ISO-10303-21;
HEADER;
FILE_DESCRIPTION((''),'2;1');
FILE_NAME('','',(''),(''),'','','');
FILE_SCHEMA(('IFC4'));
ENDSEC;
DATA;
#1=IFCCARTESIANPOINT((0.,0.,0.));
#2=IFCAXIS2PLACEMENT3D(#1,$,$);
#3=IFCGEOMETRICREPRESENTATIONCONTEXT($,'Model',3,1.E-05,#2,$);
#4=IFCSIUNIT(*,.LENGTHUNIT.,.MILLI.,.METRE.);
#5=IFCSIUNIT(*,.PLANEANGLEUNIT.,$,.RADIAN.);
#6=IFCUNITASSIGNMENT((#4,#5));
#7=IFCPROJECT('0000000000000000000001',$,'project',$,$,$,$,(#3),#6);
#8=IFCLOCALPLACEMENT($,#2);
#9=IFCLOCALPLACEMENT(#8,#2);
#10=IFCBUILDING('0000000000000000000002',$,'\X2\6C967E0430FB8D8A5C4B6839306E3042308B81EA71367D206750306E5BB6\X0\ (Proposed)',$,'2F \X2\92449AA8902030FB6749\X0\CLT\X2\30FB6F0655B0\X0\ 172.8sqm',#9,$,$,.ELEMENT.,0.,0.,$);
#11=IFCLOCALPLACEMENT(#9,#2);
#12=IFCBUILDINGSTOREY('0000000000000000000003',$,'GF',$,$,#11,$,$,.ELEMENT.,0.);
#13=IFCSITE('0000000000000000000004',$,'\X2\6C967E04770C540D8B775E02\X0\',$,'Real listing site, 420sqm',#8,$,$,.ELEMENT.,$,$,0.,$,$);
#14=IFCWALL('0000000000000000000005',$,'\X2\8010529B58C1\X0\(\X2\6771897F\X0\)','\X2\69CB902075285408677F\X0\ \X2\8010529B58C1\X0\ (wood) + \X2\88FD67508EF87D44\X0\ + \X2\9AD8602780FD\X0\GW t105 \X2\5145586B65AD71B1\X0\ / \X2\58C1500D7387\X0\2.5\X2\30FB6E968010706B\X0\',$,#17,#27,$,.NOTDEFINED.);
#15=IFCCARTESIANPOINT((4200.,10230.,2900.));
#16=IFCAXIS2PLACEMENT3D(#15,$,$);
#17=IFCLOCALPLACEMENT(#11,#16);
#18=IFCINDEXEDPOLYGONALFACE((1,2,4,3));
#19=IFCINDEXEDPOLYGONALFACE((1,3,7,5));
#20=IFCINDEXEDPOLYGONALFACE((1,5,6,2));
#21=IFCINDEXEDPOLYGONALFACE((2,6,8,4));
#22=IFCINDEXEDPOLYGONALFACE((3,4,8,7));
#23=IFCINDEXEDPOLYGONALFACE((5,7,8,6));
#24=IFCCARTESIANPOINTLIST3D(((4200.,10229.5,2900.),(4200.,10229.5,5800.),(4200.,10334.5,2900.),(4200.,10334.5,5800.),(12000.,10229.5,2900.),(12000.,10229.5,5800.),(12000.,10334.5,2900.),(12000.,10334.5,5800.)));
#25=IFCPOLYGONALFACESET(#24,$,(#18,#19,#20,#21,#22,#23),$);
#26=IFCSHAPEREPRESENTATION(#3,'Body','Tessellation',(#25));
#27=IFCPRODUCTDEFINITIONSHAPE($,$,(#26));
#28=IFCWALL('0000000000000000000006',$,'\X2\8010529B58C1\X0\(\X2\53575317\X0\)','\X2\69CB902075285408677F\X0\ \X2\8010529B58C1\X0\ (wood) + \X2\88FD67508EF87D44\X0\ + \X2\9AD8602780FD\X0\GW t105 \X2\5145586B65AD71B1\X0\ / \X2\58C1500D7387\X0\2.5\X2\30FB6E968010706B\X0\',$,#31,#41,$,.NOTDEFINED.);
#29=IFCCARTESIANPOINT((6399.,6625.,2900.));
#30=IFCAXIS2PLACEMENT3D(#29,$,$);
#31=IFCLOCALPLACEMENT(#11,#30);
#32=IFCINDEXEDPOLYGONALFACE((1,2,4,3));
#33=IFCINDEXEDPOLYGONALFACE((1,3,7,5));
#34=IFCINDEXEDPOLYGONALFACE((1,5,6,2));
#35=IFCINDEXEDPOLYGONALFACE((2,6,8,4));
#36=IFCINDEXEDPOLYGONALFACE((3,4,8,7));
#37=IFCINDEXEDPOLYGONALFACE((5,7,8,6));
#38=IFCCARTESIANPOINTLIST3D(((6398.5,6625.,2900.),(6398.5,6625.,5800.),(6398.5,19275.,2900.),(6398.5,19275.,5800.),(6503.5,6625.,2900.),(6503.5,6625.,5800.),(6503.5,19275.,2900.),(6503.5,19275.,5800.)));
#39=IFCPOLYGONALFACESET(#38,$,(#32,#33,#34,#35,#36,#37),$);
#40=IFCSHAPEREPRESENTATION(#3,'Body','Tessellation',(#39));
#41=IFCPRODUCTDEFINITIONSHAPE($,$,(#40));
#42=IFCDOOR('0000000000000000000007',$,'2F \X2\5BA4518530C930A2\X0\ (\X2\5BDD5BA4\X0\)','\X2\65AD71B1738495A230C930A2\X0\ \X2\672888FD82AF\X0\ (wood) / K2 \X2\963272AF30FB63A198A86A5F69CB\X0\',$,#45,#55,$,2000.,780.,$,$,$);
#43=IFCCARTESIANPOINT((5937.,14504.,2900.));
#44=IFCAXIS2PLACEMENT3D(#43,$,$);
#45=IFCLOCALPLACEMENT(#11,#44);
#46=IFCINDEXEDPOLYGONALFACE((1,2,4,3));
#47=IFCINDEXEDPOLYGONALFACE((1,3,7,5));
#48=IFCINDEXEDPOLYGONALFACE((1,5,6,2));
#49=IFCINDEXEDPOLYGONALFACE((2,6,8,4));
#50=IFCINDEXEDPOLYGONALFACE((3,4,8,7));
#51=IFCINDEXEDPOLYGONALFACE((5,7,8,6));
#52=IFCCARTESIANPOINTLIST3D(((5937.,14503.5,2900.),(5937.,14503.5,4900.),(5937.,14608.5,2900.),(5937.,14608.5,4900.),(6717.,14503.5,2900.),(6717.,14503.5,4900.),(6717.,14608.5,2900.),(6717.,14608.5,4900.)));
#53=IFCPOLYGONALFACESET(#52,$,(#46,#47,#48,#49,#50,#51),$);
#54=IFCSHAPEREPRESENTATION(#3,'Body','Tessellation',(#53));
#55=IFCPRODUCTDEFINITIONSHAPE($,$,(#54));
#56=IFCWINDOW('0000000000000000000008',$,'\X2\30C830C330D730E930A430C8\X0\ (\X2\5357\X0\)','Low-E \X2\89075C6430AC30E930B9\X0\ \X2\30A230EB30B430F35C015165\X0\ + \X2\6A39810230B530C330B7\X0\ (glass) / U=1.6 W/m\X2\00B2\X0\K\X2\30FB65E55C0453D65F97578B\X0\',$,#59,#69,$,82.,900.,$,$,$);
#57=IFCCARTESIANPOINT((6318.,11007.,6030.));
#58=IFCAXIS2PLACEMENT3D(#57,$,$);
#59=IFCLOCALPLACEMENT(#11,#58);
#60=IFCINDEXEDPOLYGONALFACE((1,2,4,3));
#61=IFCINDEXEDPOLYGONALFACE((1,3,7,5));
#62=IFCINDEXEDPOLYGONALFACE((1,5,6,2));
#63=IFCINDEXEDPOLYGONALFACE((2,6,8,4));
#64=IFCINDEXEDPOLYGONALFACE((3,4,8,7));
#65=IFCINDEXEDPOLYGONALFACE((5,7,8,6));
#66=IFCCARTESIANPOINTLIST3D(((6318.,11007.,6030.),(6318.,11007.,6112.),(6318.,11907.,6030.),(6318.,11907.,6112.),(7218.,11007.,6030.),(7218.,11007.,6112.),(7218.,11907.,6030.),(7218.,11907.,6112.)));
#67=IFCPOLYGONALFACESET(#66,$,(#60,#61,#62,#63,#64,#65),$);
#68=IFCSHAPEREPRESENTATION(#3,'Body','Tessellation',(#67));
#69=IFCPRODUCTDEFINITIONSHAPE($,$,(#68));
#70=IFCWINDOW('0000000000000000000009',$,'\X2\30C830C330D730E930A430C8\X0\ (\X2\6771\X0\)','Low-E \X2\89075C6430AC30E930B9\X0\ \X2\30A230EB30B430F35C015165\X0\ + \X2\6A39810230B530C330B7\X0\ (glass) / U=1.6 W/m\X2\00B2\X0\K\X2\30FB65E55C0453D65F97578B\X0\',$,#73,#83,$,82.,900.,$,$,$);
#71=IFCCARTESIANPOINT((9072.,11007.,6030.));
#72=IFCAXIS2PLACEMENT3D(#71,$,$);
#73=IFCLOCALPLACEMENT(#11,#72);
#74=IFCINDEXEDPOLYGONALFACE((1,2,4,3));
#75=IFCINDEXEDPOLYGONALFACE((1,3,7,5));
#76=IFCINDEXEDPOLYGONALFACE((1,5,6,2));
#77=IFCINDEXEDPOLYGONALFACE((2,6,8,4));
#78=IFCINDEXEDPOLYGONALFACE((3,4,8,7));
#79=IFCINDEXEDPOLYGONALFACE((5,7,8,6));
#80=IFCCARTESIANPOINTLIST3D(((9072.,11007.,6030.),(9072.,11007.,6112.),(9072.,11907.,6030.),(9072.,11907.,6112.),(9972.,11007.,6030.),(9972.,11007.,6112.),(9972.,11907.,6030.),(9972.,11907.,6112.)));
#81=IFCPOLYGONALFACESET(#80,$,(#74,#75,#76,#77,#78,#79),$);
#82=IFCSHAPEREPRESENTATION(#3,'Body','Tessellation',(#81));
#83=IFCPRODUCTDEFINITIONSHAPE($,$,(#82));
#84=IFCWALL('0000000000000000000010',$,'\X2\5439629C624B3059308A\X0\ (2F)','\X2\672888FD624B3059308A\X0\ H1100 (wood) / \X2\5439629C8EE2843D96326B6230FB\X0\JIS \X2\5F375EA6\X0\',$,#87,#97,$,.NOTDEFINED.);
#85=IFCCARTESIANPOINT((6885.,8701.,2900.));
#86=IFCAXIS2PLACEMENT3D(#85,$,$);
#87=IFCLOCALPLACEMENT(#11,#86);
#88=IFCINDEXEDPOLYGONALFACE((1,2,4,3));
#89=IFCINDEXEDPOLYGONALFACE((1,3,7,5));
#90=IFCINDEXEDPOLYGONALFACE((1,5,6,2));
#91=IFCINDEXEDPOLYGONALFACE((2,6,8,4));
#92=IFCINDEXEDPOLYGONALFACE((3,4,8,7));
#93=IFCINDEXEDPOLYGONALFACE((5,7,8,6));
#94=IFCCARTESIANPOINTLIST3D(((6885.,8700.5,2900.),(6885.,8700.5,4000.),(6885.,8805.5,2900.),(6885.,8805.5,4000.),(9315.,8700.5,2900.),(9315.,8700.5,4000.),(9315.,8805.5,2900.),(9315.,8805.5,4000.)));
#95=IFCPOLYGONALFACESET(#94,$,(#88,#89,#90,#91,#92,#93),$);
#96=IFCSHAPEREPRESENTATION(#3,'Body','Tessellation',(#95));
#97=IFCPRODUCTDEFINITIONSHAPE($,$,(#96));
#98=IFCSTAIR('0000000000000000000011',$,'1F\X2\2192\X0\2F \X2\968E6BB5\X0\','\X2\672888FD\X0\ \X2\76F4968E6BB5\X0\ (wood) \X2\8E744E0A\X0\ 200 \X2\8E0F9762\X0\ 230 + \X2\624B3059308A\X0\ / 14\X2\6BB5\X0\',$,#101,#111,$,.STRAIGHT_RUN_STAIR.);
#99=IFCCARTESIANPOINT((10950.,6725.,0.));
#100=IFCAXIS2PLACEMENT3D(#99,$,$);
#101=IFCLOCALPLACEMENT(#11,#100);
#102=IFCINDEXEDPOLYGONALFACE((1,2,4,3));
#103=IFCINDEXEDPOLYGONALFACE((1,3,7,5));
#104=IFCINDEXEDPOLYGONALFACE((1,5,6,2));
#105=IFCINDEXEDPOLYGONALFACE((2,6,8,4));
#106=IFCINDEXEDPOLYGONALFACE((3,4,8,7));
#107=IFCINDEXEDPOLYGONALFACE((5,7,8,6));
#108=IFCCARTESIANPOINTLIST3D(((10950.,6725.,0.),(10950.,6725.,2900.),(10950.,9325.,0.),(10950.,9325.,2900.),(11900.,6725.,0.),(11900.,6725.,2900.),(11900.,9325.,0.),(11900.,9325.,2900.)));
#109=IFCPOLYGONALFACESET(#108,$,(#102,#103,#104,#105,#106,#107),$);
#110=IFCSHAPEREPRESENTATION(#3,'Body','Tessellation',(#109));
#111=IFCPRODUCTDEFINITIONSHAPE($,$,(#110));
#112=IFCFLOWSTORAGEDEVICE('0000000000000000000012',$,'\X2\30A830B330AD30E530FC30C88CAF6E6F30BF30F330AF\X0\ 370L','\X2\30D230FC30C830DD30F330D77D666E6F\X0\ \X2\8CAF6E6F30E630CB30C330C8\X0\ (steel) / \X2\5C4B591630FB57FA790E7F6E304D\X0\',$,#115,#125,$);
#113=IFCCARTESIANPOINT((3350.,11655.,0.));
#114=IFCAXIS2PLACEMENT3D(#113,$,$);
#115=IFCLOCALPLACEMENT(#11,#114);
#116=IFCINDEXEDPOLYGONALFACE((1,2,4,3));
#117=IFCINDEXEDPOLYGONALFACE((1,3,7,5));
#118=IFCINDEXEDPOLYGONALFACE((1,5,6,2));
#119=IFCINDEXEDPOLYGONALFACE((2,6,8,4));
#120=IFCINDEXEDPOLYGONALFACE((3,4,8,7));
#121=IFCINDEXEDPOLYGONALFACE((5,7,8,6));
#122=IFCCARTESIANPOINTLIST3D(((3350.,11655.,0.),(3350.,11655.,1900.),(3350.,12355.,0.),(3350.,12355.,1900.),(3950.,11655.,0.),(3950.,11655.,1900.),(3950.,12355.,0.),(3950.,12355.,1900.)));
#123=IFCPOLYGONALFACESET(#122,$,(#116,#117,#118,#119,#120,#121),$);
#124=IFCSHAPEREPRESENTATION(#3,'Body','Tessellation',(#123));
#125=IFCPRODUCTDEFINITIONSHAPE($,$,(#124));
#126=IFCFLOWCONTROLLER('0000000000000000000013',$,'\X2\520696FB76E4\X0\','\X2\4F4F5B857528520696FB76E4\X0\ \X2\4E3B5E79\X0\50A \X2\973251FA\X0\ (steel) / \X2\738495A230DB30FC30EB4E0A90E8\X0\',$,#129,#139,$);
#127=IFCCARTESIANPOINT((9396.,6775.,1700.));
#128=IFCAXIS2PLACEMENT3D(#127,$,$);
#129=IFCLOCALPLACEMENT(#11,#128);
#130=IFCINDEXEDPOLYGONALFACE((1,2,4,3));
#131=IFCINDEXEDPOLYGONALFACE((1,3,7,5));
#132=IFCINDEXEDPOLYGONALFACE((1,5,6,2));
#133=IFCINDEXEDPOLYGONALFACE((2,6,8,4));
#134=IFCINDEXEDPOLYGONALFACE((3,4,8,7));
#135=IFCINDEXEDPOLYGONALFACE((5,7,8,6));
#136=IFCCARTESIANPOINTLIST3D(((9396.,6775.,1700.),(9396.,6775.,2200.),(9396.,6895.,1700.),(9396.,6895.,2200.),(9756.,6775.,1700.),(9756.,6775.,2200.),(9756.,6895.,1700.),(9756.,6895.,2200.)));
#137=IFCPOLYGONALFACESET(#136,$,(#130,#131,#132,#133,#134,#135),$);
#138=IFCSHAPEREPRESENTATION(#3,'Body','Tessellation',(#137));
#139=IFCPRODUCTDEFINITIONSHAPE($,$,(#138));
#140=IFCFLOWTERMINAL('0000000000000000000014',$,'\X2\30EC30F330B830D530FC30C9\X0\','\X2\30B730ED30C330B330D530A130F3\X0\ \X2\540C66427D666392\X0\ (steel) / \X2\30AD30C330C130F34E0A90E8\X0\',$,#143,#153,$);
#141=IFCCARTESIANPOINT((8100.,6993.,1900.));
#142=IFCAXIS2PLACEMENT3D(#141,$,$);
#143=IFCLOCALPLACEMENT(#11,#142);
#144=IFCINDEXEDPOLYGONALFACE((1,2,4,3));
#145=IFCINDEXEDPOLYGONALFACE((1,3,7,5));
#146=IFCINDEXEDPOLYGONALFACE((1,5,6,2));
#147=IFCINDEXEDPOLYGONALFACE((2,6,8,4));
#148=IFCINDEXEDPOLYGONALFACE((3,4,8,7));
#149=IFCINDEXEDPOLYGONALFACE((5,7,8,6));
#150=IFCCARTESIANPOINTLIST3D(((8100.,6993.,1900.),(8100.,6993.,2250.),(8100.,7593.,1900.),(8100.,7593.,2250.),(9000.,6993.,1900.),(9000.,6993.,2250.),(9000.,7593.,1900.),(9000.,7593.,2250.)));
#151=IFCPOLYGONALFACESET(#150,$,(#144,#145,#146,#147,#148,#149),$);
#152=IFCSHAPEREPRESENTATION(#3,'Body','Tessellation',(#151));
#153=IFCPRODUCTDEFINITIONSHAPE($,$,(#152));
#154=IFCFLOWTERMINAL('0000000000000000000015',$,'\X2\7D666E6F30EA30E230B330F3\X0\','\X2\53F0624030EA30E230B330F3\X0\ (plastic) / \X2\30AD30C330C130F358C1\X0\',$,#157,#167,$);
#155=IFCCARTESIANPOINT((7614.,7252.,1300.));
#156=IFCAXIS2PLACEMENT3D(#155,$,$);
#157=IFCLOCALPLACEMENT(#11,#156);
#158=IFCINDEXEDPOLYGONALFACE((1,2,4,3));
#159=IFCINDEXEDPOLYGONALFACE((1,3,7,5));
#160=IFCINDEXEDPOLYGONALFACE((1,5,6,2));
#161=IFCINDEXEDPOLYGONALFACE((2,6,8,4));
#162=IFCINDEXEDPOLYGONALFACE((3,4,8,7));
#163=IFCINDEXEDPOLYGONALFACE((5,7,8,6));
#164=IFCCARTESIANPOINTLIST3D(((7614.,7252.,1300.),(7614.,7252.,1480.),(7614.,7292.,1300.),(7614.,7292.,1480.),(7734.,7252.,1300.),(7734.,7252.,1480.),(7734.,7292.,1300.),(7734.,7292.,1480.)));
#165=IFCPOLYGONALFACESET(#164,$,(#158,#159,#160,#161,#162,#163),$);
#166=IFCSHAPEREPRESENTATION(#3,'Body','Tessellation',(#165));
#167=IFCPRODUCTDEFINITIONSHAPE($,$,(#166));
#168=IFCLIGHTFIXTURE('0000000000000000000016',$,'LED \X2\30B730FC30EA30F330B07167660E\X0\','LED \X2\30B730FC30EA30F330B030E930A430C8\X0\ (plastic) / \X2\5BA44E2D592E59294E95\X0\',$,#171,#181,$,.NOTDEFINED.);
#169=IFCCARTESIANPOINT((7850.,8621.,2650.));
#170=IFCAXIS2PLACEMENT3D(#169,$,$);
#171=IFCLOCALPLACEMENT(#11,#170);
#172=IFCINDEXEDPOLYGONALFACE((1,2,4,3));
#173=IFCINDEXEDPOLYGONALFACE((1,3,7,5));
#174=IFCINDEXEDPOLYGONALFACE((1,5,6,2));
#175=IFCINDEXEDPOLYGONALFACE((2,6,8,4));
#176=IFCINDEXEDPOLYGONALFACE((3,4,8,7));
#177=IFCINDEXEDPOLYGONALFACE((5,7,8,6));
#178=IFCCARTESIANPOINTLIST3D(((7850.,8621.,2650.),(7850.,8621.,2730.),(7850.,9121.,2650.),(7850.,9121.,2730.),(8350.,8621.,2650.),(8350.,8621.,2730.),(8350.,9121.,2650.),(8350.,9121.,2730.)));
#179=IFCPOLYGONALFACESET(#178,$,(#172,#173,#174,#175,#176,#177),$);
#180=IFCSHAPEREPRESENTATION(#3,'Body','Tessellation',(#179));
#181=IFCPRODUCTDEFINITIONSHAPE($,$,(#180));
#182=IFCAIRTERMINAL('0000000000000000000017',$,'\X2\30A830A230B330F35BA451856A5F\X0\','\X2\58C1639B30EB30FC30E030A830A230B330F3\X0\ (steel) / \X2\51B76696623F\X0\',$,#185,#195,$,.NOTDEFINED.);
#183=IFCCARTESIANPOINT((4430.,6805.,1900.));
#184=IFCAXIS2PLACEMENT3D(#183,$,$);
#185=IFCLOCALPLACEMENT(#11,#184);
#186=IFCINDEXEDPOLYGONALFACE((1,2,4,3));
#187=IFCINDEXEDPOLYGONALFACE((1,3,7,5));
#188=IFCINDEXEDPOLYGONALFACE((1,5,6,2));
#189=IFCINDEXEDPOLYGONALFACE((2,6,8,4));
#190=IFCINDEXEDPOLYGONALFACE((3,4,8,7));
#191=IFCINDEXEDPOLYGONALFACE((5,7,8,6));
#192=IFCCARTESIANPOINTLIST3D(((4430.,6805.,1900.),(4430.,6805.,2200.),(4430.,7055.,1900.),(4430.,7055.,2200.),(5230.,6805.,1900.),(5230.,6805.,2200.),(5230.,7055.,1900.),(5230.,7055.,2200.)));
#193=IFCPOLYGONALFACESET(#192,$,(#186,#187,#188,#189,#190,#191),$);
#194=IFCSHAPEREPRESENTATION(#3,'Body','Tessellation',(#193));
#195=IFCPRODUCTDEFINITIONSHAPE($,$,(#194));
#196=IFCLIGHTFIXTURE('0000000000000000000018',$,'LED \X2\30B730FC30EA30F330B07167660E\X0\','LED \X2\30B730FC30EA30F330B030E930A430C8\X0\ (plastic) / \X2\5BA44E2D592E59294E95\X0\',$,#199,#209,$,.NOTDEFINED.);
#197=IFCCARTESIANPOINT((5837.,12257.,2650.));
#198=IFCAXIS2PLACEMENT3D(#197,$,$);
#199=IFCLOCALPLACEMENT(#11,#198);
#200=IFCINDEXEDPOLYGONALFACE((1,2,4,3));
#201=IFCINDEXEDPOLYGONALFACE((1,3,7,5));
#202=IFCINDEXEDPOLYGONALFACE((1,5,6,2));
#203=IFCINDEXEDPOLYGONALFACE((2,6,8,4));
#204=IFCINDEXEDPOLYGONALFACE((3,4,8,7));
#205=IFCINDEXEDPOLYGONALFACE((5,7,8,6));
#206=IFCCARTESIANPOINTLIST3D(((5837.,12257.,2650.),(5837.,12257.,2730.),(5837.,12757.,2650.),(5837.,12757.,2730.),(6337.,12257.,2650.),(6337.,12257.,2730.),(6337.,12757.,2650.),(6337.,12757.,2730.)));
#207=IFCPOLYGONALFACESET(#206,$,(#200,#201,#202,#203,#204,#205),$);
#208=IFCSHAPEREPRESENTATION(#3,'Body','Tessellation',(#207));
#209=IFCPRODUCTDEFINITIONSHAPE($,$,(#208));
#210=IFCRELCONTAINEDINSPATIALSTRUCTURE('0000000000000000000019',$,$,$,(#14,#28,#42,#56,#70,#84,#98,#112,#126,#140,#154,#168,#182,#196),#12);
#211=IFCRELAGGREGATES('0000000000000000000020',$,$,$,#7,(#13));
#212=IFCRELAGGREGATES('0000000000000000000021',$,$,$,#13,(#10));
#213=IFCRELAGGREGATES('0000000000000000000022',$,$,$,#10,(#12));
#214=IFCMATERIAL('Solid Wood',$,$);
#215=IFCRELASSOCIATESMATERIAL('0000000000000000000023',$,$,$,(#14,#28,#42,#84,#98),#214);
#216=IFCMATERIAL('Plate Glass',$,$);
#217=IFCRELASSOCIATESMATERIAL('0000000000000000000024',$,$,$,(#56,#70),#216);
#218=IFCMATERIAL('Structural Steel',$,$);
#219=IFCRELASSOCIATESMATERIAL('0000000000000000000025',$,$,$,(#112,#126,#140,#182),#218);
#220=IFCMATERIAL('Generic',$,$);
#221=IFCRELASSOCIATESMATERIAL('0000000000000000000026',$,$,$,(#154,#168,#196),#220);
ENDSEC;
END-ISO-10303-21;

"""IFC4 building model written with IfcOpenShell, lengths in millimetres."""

from ifc_helpers import new_model, si_unit, frame, frame_2d, origin, place, context, project, spatial, rectangle, extrude, material, element, fill, save


model = new_model("IFC4")

# Units and contexts
model_context = context("Model", 3, precision=1e-05, world=origin())
ifc_project = project(units=[si_unit("LENGTHUNIT", "METRE", prefix="MILLI"), si_unit("PLANEANGLEUNIT", "RADIAN")], contexts=[model_context])

# Site, building, storey
site_placement = place(None, origin())
site = spatial("IfcSite", under=ifc_project, at=site_placement, Name="沖縄県名護市", ObjectType="Real listing site, 420sqm", CompositionType="ELEMENT", RefElevation=0.0)
building_placement = place(site_placement, origin())
building = spatial("IfcBuilding", under=site, at=building_placement, Name="沖縄・越屋根のある自然素材の家 (Proposed)", ObjectType="2F 鉄骨造・杉CLT・漆喰 172.8sqm", CompositionType="ELEMENT", ElevationOfRefHeight=0.0, ElevationOfTerrain=0.0)
storey_placement = place(building_placement, origin())
storey = spatial("IfcBuildingStorey", under=building, at=storey_placement, Name="GF", CompositionType="ELEMENT", Elevation=0.0)

# Shared definitions
ifc_material_1 = material(Name="Solid Wood")

# Wall
wall_1_placement = place(storey_placement, frame((4200.0, 10230.0, 2900.0)))
element("IfcWall", 1, at=wall_1_placement, inside=storey, material=ifc_material_1, Name="耐力壁(東西)", Description="構造用合板 耐力壁 (wood) + 製材軸組 + 高性能GW t105 充填断熱 / 壁倍率2.5・準耐火", PredefinedType="NOTDEFINED", context=model_context, shape_type="SweptSolid", body=[
    extrude(rectangle(XDim=7800.0, YDim=105.0, at=frame_2d((3900.0, 52.0))), frame((4200.0, 10230.0, 2900.0)), (0.0, 0.0, 1.0), 2900.0),
])

# Wall, opening, door
wall_2_placement = place(storey_placement, frame((6399.0, 6625.0, 2900.0)))
wall_2 = element("IfcWall", 2, at=wall_2_placement, inside=storey, material=ifc_material_1, Name="耐力壁(南北)", Description="構造用合板 耐力壁 (wood) + 製材軸組 + 高性能GW t105 充填断熱 / 壁倍率2.5・準耐火", PredefinedType="NOTDEFINED", context=model_context, shape_type="SweptSolid", body=[
    extrude(rectangle(XDim=105.0, YDim=12650.0, at=frame_2d((52.0, 6325.0))), frame((6399.0, 6625.0, 2900.0)), (0.0, 0.0, 1.0), 2900.0),
])
opening_placement = place(storey_placement, frame((5937.0, 14504.0, 2900.0)))
opening = element("IfcOpeningElement", 3, at=opening_placement, cuts=wall_2, PredefinedType="NOTDEFINED", context=model_context, shape_type="SweptSolid", body=[
    extrude(rectangle(XDim=780.0, YDim=105.0, at=frame_2d((390.0, 52.0))), frame((5937.0, 14504.0, 2900.0)), (0.0, 0.0, 1.0), 2000.0),
])
door_placement = place(storey_placement, frame((5937.0, 14504.0, 2900.0)))
door = element("IfcDoor", 4, at=door_placement, inside=storey, material=ifc_material_1, Name="2F 室内ドア (寝室)", Description="断熱玄関ドア 木製芯 (wood) / K2 防犯・採風機構", OverallHeight=2000.0, OverallWidth=780.0, context=model_context, shape_type="SweptSolid", body=[
    extrude(rectangle(XDim=780.0, YDim=105.0, at=frame_2d((390.0, 52.0))), frame((5937.0, 14504.0, 2900.0)), (0.0, 0.0, 1.0), 2000.0),
])
fill(opening, door)

# Windows
ifc_material_2 = material(Name="Plate Glass")
window_1_placement = place(storey_placement, frame((6318.0, 11007.0, 6030.0)))
element("IfcWindow", 5, at=window_1_placement, inside=storey, material=ifc_material_2, Name="トップライト (南)", Description="Low-E 複層ガラス アルゴン封入 + 樹脂サッシ (glass) / U=1.6 W/m²K・日射取得型", OverallHeight=82.0, OverallWidth=900.0, context=model_context, shape_type="SweptSolid", body=[
    extrude(rectangle(XDim=900.0, YDim=900.0, at=frame_2d((450.0, 450.0))), frame((6318.0, 11007.0, 6030.0)), (0.0, 0.0, 1.0), 82.0),
])
window_2_placement = place(storey_placement, frame((9072.0, 11007.0, 6030.0)))
element("IfcWindow", 6, at=window_2_placement, inside=storey, material=ifc_material_2, Name="トップライト (東)", Description="Low-E 複層ガラス アルゴン封入 + 樹脂サッシ (glass) / U=1.6 W/m²K・日射取得型", OverallHeight=82.0, OverallWidth=900.0, context=model_context, shape_type="SweptSolid", body=[
    extrude(rectangle(XDim=900.0, YDim=900.0, at=frame_2d((450.0, 450.0))), frame((9072.0, 11007.0, 6030.0)), (0.0, 0.0, 1.0), 82.0),
])

# Wall
wall_3_placement = place(storey_placement, frame((6885.0, 8701.0, 2900.0)))
element("IfcWall", 7, at=wall_3_placement, inside=storey, material=ifc_material_1, Name="吹抜手すり (2F)", Description="木製手すり H1100 (wood) / 吹抜転落防止・JIS 強度", PredefinedType="NOTDEFINED", context=model_context, shape_type="SweptSolid", body=[
    extrude(rectangle(XDim=2430.0, YDim=105.0, at=frame_2d((1215.0, 52.0))), frame((6885.0, 8701.0, 2900.0)), (0.0, 0.0, 1.0), 1100.0),
])

# Stair
stair_placement = place(storey_placement, frame((10950.0, 6725.0, 0.0)))
element("IfcStair", 8, at=stair_placement, inside=storey, material=ifc_material_1, Name="1F→2F 階段", Description="木製 直階段 (wood) 蹴上 200 踏面 230 + 手すり / 14段", PredefinedType="STRAIGHT_RUN_STAIR", context=model_context, shape_type="SweptSolid", body=[
    extrude(rectangle(XDim=950.0, YDim=2600.0, at=frame_2d((475.0, 1300.0))), frame((10950.0, 6725.0, 0.0)), (0.0, 0.0, 1.0), 2900.0),
])

# Flow storage device
ifc_material_3 = material(Name="Structural Steel")
flow_storage_device_placement = place(storey_placement, frame((3350.0, 11655.0, 0.0)))
element("IfcFlowStorageDevice", 9, at=flow_storage_device_placement, inside=storey, material=ifc_material_3, Name="エコキュート貯湯タンク 370L", Description="ヒートポンプ給湯 貯湯ユニット (steel) / 屋外・基礎置き", context=model_context, shape_type="SweptSolid", body=[
    extrude(rectangle(XDim=600.0, YDim=700.0, at=frame_2d((300.0, 350.0))), frame((3350.0, 11655.0, 0.0)), (0.0, 0.0, 1.0), 1900.0),
])

# Flow controller
flow_controller_placement = place(storey_placement, frame((9396.0, 6775.0, 1700.0)))
element("IfcFlowController", 10, at=flow_controller_placement, inside=storey, material=ifc_material_3, Name="分電盤", Description="住宅用分電盤 主幹50A 露出 (steel) / 玄関ホール上部", context=model_context, shape_type="SweptSolid", body=[
    extrude(rectangle(XDim=360.0, YDim=120.0, at=frame_2d((180.0, 60.0))), frame((9396.0, 6775.0, 1700.0)), (0.0, 0.0, 1.0), 500.0),
])

# Flow terminals
flow_terminal_1_placement = place(storey_placement, frame((8100.0, 6993.0, 1900.0)))
element("IfcFlowTerminal", 11, at=flow_terminal_1_placement, inside=storey, material=ifc_material_3, Name="レンジフード", Description="シロッコファン 同時給排 (steel) / キッチン上部", context=model_context, shape_type="SweptSolid", body=[
    extrude(rectangle(XDim=900.0, YDim=600.0, at=frame_2d((450.0, 300.0))), frame((8100.0, 6993.0, 1900.0)), (0.0, 0.0, 1.0), 350.0),
])
ifc_material_4 = material(Name="Generic")
flow_terminal_2_placement = place(storey_placement, frame((7614.0, 7252.0, 1300.0)))
element("IfcFlowTerminal", 12, at=flow_terminal_2_placement, inside=storey, material=ifc_material_4, Name="給湯リモコン", Description="台所リモコン (plastic) / キッチン壁", context=model_context, shape_type="SweptSolid", body=[
    extrude(rectangle(XDim=120.0, YDim=40.0, at=frame_2d((60.0, 20.0))), frame((7614.0, 7252.0, 1300.0)), (0.0, 0.0, 1.0), 180.0),
])

# Light fixture
light_fixture_1_placement = place(storey_placement, frame((7850.0, 8621.0, 2650.0)))
element("IfcLightFixture", 13, at=light_fixture_1_placement, inside=storey, material=ifc_material_4, Name="LED シーリング照明", Description="LED シーリングライト (plastic) / 室中央天井", PredefinedType="NOTDEFINED", context=model_context, shape_type="SweptSolid", body=[
    extrude(rectangle(XDim=500.0, YDim=500.0, at=frame_2d((250.0, 250.0))), frame((7850.0, 8621.0, 2650.0)), (0.0, 0.0, 1.0), 80.0),
])

# Air terminal
air_terminal_1_placement = place(storey_placement, frame((4430.0, 6805.0, 1900.0)))
element("IfcAirTerminal", 14, at=air_terminal_1_placement, inside=storey, material=ifc_material_3, Name="エアコン室内機", Description="壁掛ルームエアコン (steel) / 冷暖房", PredefinedType="NOTDEFINED", context=model_context, shape_type="SweptSolid", body=[
    extrude(rectangle(XDim=800.0, YDim=250.0, at=frame_2d((400.0, 125.0))), frame((4430.0, 6805.0, 1900.0)), (0.0, 0.0, 1.0), 300.0),
])

# Light fixture
light_fixture_2_placement = place(storey_placement, frame((5837.0, 12257.0, 2650.0)))
element("IfcLightFixture", 15, at=light_fixture_2_placement, inside=storey, material=ifc_material_4, Name="LED シーリング照明", Description="LED シーリングライト (plastic) / 室中央天井", PredefinedType="NOTDEFINED", context=model_context, shape_type="SweptSolid", body=[
    extrude(rectangle(XDim=500.0, YDim=500.0, at=frame_2d((250.0, 250.0))), frame((5837.0, 12257.0, 2650.0)), (0.0, 0.0, 1.0), 80.0),
])

save(model, "model.ifc")
